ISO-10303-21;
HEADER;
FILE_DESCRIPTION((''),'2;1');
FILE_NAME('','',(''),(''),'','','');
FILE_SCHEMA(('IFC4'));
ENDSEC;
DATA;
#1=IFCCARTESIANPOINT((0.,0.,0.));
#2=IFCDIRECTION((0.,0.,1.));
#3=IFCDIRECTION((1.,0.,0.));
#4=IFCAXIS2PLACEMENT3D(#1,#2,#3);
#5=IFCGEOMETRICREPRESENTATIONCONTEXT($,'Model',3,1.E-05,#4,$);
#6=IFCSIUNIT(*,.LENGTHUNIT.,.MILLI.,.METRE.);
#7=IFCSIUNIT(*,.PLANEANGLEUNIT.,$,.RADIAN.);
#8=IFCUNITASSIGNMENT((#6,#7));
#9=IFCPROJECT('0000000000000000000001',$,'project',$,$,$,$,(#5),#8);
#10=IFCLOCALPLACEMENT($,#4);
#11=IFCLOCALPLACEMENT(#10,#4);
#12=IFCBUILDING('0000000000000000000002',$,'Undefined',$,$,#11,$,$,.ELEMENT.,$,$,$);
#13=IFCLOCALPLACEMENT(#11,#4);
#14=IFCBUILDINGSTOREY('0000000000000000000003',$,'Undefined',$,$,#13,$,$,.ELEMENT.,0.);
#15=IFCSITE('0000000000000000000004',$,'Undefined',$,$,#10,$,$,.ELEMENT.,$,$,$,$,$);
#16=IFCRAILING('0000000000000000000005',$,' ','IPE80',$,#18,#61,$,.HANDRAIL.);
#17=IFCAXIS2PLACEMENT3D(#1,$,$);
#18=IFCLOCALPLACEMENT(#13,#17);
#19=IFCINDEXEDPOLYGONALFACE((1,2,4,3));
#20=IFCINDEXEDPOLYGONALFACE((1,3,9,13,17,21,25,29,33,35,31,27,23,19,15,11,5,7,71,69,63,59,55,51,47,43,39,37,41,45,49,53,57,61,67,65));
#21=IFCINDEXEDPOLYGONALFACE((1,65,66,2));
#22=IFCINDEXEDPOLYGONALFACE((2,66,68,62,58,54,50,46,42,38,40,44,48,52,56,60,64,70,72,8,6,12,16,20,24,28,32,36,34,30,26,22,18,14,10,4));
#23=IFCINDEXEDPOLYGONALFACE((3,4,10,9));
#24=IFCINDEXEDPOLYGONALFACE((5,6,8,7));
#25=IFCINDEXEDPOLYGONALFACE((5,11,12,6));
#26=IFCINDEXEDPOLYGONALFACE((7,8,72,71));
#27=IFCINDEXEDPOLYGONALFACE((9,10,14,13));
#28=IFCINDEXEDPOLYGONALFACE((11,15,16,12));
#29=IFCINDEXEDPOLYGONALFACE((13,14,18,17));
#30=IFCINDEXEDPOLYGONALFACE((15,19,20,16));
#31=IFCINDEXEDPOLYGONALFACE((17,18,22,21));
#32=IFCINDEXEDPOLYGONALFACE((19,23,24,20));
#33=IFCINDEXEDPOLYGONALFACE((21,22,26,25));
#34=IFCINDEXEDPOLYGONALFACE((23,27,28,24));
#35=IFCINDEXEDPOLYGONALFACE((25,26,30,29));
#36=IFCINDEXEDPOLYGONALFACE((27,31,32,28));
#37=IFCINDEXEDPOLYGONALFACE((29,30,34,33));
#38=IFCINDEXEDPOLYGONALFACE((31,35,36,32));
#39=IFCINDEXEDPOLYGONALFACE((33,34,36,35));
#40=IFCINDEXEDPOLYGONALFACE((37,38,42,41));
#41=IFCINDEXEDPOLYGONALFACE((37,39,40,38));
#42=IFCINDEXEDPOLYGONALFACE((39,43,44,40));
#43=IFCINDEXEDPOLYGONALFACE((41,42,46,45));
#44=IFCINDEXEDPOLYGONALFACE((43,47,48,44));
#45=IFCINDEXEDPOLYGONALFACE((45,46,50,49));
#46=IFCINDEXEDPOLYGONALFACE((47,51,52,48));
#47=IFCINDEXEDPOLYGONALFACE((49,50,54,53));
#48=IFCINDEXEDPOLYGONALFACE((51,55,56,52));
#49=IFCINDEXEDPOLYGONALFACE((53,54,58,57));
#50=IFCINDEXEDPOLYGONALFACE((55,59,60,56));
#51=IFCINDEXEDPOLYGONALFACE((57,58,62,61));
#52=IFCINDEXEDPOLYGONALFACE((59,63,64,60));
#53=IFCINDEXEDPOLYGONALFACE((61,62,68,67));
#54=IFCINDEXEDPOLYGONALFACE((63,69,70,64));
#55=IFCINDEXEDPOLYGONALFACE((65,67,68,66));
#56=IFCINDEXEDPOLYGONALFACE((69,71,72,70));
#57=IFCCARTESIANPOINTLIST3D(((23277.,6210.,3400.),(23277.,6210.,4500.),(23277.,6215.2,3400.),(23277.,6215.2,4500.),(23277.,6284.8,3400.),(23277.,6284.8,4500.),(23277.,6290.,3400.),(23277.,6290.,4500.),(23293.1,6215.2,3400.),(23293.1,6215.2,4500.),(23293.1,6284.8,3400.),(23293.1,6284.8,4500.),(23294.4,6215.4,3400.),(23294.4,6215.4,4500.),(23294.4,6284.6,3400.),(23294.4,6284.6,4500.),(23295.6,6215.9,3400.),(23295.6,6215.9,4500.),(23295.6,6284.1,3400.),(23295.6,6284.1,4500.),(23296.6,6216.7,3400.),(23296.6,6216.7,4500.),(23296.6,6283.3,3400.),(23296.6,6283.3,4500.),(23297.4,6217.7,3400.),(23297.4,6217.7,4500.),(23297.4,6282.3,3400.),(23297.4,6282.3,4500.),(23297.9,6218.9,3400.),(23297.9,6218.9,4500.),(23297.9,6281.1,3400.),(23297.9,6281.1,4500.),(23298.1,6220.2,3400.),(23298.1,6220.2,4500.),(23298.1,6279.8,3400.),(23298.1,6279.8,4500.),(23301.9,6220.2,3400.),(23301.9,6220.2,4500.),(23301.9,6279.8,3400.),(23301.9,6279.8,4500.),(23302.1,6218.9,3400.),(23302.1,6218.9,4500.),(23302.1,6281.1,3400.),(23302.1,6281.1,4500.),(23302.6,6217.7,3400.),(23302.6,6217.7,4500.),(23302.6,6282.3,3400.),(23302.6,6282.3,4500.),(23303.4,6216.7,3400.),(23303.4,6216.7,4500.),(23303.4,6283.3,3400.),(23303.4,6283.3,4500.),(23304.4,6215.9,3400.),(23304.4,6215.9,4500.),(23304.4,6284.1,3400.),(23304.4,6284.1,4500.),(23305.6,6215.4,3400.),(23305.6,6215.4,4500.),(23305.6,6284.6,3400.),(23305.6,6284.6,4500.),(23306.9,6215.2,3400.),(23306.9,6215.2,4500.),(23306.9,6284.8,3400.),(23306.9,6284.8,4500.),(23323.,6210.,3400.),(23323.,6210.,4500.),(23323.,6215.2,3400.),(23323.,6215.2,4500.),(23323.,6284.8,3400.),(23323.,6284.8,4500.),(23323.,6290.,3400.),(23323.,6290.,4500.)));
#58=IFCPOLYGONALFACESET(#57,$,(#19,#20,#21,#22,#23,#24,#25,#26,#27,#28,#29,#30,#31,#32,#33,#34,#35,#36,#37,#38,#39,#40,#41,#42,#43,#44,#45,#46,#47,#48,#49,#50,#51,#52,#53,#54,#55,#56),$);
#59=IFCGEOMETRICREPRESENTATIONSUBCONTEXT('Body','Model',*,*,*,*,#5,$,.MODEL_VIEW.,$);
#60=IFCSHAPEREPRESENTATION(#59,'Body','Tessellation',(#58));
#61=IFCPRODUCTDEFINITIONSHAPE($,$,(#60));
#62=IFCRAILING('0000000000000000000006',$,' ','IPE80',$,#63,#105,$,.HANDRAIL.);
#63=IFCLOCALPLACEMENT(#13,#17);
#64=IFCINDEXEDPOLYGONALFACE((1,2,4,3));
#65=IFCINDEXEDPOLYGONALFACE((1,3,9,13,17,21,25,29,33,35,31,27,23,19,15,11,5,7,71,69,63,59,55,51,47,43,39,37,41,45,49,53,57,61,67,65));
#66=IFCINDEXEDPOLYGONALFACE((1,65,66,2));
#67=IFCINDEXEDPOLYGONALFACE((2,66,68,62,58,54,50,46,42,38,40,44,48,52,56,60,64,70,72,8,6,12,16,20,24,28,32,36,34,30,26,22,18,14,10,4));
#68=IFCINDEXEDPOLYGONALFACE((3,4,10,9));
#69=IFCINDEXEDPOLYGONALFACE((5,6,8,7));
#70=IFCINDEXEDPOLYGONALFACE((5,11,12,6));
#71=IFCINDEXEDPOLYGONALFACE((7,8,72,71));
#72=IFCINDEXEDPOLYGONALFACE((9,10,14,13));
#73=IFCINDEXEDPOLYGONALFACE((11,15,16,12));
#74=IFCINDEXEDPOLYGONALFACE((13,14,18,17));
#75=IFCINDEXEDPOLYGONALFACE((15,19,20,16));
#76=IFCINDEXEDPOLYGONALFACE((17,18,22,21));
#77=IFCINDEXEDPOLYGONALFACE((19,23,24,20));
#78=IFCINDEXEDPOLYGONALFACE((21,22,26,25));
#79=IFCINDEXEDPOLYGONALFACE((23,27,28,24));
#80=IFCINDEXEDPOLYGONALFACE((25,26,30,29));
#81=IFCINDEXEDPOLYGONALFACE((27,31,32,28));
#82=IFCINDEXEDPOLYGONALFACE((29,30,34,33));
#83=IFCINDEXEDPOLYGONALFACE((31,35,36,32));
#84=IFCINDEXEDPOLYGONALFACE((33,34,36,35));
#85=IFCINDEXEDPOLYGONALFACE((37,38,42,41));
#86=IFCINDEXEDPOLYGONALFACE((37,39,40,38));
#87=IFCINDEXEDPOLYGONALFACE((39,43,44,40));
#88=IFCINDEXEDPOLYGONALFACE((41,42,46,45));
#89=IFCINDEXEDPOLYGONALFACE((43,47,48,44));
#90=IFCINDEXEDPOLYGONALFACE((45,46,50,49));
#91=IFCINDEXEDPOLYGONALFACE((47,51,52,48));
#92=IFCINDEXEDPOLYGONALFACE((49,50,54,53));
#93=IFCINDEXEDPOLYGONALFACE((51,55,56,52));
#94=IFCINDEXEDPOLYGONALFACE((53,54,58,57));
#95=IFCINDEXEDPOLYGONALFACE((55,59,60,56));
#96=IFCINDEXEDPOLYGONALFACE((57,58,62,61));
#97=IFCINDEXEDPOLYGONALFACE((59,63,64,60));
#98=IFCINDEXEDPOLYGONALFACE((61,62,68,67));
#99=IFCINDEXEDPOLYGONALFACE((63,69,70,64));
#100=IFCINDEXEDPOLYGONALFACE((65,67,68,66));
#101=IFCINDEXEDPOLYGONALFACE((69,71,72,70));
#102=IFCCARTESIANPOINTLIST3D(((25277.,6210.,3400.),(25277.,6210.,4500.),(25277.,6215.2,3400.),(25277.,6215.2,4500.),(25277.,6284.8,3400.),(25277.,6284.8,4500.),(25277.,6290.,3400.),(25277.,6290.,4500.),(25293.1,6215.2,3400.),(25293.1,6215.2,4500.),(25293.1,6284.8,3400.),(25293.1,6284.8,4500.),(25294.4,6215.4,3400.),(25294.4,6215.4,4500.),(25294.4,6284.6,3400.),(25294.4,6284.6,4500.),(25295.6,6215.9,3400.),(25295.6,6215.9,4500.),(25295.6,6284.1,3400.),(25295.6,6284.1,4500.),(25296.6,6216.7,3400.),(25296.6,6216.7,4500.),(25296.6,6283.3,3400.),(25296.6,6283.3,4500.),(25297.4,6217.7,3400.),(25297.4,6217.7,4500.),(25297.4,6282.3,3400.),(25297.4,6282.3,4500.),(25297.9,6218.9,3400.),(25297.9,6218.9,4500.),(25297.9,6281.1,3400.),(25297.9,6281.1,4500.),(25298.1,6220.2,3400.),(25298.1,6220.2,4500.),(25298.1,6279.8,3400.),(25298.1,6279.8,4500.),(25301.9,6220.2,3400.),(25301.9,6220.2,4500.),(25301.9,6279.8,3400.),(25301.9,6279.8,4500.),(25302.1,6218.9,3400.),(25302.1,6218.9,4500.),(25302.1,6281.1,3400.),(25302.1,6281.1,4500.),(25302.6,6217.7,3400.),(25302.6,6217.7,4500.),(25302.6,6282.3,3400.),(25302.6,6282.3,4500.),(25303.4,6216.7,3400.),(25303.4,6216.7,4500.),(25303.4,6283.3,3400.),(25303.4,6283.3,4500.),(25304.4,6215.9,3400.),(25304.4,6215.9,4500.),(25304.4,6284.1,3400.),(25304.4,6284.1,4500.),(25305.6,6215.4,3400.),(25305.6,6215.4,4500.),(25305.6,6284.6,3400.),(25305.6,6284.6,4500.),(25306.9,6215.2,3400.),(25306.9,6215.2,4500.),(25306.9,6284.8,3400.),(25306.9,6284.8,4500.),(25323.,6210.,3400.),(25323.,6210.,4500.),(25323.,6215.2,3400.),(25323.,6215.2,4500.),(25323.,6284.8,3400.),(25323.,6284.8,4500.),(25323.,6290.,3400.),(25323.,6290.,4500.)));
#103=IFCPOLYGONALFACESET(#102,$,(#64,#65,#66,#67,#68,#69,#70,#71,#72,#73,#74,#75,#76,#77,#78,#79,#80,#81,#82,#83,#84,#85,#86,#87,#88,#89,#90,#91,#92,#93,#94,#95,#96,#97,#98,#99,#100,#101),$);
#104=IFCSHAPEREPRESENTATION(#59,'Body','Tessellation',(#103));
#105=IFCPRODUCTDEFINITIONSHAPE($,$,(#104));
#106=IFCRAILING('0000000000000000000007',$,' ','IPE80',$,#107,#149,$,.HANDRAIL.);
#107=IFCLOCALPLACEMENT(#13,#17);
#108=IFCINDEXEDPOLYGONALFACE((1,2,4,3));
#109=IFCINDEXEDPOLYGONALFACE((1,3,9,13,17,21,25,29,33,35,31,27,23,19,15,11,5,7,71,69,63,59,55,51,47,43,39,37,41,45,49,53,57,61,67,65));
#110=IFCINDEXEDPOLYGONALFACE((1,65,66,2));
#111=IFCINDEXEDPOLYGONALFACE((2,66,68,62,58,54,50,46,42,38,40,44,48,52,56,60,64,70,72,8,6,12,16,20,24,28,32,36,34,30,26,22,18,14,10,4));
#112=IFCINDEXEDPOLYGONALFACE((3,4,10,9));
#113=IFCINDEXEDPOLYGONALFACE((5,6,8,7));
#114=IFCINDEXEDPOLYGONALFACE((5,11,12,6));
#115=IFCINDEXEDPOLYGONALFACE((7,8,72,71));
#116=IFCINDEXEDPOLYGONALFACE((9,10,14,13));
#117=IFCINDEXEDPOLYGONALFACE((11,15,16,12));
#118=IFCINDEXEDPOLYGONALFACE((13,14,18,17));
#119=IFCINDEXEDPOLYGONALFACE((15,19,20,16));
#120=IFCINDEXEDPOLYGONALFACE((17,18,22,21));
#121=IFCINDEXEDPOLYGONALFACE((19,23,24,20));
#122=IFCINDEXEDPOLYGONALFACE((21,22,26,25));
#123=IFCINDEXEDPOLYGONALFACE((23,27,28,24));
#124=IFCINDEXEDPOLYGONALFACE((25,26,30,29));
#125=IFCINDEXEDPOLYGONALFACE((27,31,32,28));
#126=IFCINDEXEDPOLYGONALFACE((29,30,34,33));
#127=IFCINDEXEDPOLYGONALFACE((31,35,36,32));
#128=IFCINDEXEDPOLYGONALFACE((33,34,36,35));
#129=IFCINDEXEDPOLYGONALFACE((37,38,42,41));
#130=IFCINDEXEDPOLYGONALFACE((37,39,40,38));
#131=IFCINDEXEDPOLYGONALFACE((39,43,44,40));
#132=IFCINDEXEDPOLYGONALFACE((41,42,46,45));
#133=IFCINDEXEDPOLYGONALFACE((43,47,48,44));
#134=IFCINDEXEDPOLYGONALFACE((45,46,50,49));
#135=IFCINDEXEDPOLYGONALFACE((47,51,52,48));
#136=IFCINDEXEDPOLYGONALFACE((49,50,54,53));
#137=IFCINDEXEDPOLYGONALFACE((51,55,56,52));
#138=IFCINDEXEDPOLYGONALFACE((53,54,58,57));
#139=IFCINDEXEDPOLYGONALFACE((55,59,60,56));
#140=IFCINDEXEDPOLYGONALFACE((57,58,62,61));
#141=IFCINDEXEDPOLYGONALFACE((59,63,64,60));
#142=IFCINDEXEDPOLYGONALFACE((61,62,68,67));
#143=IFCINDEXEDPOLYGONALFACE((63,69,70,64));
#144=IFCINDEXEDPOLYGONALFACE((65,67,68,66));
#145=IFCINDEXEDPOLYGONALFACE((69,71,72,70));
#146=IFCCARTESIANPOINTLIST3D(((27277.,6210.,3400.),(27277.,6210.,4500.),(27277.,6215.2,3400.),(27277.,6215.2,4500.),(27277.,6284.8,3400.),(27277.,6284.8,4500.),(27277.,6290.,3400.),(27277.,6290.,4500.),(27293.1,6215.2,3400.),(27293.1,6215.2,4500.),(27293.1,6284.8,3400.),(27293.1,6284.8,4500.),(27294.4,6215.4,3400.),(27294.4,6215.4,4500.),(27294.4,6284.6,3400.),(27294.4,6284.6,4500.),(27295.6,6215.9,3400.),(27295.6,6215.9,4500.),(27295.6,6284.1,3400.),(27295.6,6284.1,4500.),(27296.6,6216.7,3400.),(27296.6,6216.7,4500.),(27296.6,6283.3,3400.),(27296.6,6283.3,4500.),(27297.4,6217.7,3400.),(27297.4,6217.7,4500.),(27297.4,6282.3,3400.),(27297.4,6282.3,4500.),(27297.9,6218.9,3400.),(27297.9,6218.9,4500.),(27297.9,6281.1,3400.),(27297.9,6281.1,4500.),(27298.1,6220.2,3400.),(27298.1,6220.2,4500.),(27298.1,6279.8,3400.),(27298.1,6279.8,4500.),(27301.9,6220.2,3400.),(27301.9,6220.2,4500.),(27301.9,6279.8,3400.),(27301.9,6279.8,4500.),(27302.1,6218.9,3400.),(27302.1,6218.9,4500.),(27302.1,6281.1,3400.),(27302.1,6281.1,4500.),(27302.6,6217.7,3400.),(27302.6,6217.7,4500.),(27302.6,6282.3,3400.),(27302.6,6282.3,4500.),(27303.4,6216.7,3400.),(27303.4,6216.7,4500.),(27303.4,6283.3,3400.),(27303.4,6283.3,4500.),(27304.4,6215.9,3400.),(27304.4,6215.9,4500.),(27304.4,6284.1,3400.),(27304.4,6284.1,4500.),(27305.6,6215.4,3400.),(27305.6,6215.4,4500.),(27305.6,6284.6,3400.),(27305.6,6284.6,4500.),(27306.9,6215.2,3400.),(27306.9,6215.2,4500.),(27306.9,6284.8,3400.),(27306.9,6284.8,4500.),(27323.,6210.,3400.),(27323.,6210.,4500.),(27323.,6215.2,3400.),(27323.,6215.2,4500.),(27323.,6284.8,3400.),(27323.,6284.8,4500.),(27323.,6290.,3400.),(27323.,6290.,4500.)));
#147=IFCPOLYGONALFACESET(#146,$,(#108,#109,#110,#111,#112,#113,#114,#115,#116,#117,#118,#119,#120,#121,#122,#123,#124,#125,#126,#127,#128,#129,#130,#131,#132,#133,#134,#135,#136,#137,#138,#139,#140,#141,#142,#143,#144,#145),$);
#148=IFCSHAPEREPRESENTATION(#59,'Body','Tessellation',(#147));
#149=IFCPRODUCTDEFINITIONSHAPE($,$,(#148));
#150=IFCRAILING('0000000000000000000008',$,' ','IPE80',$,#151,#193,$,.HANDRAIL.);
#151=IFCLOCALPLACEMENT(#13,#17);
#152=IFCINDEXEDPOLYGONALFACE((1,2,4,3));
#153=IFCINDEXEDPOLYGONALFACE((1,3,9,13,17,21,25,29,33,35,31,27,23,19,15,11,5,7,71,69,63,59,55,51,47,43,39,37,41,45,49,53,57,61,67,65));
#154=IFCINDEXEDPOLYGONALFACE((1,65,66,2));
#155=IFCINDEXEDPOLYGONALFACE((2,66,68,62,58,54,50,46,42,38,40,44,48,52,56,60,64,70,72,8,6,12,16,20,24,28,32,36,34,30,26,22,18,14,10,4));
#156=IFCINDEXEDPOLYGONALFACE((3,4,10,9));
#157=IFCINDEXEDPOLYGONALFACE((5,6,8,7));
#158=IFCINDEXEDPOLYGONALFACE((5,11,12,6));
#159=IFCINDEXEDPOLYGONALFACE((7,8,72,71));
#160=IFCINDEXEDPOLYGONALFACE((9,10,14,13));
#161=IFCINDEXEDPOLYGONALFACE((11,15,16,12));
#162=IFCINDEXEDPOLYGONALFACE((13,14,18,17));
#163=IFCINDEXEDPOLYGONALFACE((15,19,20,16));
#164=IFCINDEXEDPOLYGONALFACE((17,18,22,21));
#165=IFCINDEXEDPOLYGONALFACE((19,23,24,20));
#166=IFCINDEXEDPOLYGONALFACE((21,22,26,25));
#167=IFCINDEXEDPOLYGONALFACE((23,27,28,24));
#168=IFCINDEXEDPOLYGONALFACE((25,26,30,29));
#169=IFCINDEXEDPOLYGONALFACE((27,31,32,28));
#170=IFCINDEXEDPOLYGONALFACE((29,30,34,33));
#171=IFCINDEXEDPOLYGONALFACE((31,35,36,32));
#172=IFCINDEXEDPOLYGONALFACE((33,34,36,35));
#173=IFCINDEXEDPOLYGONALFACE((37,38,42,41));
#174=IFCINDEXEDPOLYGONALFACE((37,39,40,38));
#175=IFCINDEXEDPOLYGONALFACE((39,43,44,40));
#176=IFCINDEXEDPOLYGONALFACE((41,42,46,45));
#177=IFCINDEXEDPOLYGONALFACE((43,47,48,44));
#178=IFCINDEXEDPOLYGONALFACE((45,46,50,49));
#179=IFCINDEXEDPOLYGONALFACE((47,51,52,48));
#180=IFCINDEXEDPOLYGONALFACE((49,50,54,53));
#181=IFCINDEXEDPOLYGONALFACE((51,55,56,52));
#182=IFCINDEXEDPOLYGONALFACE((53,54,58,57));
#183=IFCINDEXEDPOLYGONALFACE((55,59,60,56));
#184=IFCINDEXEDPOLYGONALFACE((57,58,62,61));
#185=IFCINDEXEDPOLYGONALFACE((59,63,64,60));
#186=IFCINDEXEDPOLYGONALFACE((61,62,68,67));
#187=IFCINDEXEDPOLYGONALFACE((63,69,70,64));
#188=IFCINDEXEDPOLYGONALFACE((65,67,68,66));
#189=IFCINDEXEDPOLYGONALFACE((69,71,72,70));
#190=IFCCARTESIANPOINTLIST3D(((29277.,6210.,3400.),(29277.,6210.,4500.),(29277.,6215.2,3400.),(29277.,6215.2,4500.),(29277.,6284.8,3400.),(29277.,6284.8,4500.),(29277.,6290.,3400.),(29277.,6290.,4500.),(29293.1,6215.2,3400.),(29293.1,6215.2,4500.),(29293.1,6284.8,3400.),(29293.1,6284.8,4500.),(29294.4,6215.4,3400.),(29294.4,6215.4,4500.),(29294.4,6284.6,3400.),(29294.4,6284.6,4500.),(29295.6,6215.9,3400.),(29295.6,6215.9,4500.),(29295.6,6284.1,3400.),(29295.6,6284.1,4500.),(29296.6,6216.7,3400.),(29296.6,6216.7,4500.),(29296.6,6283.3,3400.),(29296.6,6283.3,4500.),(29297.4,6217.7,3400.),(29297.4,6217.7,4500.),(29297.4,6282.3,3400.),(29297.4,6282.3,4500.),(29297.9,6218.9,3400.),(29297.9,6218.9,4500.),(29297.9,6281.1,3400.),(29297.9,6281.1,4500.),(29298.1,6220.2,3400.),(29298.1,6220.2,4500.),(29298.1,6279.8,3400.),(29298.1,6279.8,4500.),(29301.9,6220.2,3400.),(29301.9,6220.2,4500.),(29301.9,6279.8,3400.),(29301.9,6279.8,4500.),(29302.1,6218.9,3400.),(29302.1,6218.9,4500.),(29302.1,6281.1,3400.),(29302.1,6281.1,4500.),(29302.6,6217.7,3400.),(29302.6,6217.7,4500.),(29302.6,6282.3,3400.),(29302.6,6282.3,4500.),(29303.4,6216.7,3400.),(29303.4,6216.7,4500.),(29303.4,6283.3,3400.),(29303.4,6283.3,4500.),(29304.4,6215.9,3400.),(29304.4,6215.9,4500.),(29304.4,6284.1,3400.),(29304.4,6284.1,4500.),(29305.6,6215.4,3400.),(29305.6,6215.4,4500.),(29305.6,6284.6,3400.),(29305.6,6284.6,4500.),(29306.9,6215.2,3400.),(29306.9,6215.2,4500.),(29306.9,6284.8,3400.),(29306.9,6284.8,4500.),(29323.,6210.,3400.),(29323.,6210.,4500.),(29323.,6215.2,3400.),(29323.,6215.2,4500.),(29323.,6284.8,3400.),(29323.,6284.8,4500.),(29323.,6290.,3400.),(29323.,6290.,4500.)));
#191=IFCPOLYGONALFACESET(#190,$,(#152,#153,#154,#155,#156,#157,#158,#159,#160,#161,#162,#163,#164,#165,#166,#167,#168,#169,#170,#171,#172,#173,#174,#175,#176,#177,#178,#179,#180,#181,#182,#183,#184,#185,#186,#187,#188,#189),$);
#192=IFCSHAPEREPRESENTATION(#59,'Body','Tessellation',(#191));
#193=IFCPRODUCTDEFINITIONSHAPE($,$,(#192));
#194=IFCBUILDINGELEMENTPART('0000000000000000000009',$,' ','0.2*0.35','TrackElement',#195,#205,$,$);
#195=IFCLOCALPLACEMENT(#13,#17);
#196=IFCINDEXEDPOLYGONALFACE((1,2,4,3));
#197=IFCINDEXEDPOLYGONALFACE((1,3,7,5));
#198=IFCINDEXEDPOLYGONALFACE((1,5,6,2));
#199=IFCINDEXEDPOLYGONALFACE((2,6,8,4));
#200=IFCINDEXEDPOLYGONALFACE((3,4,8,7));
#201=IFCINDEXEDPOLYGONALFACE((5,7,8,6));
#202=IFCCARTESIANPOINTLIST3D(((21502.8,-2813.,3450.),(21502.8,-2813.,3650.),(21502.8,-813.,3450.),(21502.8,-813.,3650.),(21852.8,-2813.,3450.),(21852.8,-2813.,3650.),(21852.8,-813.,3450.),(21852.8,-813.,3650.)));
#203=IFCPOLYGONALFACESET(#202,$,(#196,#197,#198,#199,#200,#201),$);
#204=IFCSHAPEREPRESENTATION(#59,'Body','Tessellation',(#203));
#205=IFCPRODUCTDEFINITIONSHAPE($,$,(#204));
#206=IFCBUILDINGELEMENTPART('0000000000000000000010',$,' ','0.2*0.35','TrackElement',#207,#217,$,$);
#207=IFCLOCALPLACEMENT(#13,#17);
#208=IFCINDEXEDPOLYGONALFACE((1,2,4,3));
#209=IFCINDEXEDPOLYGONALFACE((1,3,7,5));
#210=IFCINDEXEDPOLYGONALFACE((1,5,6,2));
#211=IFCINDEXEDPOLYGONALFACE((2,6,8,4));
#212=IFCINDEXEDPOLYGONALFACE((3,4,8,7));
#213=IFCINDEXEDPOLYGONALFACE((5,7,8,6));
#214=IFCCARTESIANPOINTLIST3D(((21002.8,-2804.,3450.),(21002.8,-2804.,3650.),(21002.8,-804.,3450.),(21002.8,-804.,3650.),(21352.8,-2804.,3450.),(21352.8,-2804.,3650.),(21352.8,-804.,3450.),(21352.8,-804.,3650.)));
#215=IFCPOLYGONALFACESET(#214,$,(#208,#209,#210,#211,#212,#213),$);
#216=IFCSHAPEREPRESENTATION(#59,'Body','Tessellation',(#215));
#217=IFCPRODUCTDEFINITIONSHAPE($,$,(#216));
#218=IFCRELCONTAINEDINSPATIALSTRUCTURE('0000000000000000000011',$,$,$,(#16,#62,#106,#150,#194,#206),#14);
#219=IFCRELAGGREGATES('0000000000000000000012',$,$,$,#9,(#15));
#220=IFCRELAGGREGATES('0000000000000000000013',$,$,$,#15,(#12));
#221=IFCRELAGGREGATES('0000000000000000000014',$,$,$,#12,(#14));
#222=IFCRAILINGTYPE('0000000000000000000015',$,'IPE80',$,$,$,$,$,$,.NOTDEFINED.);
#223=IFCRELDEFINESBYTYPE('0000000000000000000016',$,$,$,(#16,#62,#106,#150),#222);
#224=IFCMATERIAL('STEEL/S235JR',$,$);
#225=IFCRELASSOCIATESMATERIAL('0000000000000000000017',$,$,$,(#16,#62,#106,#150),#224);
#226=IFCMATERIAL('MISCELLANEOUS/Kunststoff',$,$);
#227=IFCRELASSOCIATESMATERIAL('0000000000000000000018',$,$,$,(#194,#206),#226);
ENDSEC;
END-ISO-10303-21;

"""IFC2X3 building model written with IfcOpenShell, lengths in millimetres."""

from ifc_helpers import new_model, si_unit, frame, origin_with_axes, origin_2d_with_axis, place, context, subcontext, project, spatial, rectangle, i_section, extrude, material, type_object, element, save


model = new_model("IFC2X3")

# Units and contexts
model_context = context("Model", 3, precision=1e-05, world=origin_with_axes())
body_context = subcontext(model_context, "Body", "Model", "MODEL_VIEW")
ifc_project = project(units=[si_unit("LENGTHUNIT", "METRE", prefix="MILLI"), si_unit("PLANEANGLEUNIT", "RADIAN")], contexts=[model_context])

# Site, building, storey
site_placement = place(None, origin_with_axes())
site = spatial("IfcSite", under=ifc_project, at=site_placement, Name="Undefined", CompositionType="ELEMENT")
building_placement = place(site_placement, origin_with_axes())
building = spatial("IfcBuilding", under=site, at=building_placement, Name="Undefined", CompositionType="ELEMENT")
storey_placement = place(building_placement, origin_with_axes())
storey = spatial("IfcBuildingStorey", under=building, at=storey_placement, Name="Undefined", CompositionType="ELEMENT", Elevation=0.0)

# Shared definitions
ifc_material_1 = material(Name="STEEL/S235JR")

# Railings
railing_type_1 = type_object("IfcRailingType", Name="IPE80", PredefinedType="NOTDEFINED")
for number, where, z_axis, x_axis, name in (
    (1, (23300.0, 6250.0, 3400.0), (0.0, 1.0, 0.0), (0.0, 0.0, 1.0), " "),
    (2, (25300.0, 6250.0, 3400.0), (0.0, 1.0, 0.0), (0.0, 0.0, 1.0), " "),
    (3, (27300.0, 6250.0, 3400.0), (0.0, 1.0, 0.0), (0.0, 0.0, 1.0), " "),
    (4, (29300.0, 6250.0, 3400.0), (0.0, 1.0, 0.0), (0.0, 0.0, 1.0), " "),
):
    element("IfcRailing", number, at=place(storey_placement, frame(where, z_axis=z_axis, x_axis=x_axis)), inside=storey, type_object=railing_type_1, material=ifc_material_1, Name=name, Description="IPE80", PredefinedType="HANDRAIL", context=body_context, shape_type="SweptSolid", body=[
        extrude(i_section(OverallWidth=46.0, OverallDepth=80.0, WebThickness=3.8, FlangeThickness=5.2, FilletRadius=5.0, at=origin_2d_with_axis()), frame((1100.0, 0.0, 0.0), z_axis=(-1.0, 0.0, 0.0), x_axis=(0.0, -1.0, 0.0)), (0.0, 0.0, 1.0), 1100.0),
    ])

# Building element parts
ifc_material_2 = material(Name="MISCELLANEOUS/Kunststoff")
for number, where, z_axis, x_axis, name in (
    (5, (21677.8, -813.0, 3550.0), (0.0, 0.0, 1.0), (0.0, -1.0, 0.0), " "),
    (6, (21177.8, -804.0, 3550.0), (0.0, 0.0, 1.0), (0.0, -1.0, 0.0), " "),
):
    element("IfcBuildingElementPart", number, at=place(storey_placement, frame(where, z_axis=z_axis, x_axis=x_axis)), inside=storey, material=ifc_material_2, Name=name, Description="0.2*0.35", ObjectType="TrackElement", context=body_context, shape_type="SweptSolid", body=[
        extrude(rectangle(XDim=350.0, YDim=200.0, at=origin_2d_with_axis()), frame((2000.0, 0.0, 0.0), z_axis=(-1.0, 0.0, 0.0), x_axis=(0.0, -1.0, 0.0)), (0.0, 0.0, 1.0), 2000.0),
    ])

save(model, "model.ifc")
